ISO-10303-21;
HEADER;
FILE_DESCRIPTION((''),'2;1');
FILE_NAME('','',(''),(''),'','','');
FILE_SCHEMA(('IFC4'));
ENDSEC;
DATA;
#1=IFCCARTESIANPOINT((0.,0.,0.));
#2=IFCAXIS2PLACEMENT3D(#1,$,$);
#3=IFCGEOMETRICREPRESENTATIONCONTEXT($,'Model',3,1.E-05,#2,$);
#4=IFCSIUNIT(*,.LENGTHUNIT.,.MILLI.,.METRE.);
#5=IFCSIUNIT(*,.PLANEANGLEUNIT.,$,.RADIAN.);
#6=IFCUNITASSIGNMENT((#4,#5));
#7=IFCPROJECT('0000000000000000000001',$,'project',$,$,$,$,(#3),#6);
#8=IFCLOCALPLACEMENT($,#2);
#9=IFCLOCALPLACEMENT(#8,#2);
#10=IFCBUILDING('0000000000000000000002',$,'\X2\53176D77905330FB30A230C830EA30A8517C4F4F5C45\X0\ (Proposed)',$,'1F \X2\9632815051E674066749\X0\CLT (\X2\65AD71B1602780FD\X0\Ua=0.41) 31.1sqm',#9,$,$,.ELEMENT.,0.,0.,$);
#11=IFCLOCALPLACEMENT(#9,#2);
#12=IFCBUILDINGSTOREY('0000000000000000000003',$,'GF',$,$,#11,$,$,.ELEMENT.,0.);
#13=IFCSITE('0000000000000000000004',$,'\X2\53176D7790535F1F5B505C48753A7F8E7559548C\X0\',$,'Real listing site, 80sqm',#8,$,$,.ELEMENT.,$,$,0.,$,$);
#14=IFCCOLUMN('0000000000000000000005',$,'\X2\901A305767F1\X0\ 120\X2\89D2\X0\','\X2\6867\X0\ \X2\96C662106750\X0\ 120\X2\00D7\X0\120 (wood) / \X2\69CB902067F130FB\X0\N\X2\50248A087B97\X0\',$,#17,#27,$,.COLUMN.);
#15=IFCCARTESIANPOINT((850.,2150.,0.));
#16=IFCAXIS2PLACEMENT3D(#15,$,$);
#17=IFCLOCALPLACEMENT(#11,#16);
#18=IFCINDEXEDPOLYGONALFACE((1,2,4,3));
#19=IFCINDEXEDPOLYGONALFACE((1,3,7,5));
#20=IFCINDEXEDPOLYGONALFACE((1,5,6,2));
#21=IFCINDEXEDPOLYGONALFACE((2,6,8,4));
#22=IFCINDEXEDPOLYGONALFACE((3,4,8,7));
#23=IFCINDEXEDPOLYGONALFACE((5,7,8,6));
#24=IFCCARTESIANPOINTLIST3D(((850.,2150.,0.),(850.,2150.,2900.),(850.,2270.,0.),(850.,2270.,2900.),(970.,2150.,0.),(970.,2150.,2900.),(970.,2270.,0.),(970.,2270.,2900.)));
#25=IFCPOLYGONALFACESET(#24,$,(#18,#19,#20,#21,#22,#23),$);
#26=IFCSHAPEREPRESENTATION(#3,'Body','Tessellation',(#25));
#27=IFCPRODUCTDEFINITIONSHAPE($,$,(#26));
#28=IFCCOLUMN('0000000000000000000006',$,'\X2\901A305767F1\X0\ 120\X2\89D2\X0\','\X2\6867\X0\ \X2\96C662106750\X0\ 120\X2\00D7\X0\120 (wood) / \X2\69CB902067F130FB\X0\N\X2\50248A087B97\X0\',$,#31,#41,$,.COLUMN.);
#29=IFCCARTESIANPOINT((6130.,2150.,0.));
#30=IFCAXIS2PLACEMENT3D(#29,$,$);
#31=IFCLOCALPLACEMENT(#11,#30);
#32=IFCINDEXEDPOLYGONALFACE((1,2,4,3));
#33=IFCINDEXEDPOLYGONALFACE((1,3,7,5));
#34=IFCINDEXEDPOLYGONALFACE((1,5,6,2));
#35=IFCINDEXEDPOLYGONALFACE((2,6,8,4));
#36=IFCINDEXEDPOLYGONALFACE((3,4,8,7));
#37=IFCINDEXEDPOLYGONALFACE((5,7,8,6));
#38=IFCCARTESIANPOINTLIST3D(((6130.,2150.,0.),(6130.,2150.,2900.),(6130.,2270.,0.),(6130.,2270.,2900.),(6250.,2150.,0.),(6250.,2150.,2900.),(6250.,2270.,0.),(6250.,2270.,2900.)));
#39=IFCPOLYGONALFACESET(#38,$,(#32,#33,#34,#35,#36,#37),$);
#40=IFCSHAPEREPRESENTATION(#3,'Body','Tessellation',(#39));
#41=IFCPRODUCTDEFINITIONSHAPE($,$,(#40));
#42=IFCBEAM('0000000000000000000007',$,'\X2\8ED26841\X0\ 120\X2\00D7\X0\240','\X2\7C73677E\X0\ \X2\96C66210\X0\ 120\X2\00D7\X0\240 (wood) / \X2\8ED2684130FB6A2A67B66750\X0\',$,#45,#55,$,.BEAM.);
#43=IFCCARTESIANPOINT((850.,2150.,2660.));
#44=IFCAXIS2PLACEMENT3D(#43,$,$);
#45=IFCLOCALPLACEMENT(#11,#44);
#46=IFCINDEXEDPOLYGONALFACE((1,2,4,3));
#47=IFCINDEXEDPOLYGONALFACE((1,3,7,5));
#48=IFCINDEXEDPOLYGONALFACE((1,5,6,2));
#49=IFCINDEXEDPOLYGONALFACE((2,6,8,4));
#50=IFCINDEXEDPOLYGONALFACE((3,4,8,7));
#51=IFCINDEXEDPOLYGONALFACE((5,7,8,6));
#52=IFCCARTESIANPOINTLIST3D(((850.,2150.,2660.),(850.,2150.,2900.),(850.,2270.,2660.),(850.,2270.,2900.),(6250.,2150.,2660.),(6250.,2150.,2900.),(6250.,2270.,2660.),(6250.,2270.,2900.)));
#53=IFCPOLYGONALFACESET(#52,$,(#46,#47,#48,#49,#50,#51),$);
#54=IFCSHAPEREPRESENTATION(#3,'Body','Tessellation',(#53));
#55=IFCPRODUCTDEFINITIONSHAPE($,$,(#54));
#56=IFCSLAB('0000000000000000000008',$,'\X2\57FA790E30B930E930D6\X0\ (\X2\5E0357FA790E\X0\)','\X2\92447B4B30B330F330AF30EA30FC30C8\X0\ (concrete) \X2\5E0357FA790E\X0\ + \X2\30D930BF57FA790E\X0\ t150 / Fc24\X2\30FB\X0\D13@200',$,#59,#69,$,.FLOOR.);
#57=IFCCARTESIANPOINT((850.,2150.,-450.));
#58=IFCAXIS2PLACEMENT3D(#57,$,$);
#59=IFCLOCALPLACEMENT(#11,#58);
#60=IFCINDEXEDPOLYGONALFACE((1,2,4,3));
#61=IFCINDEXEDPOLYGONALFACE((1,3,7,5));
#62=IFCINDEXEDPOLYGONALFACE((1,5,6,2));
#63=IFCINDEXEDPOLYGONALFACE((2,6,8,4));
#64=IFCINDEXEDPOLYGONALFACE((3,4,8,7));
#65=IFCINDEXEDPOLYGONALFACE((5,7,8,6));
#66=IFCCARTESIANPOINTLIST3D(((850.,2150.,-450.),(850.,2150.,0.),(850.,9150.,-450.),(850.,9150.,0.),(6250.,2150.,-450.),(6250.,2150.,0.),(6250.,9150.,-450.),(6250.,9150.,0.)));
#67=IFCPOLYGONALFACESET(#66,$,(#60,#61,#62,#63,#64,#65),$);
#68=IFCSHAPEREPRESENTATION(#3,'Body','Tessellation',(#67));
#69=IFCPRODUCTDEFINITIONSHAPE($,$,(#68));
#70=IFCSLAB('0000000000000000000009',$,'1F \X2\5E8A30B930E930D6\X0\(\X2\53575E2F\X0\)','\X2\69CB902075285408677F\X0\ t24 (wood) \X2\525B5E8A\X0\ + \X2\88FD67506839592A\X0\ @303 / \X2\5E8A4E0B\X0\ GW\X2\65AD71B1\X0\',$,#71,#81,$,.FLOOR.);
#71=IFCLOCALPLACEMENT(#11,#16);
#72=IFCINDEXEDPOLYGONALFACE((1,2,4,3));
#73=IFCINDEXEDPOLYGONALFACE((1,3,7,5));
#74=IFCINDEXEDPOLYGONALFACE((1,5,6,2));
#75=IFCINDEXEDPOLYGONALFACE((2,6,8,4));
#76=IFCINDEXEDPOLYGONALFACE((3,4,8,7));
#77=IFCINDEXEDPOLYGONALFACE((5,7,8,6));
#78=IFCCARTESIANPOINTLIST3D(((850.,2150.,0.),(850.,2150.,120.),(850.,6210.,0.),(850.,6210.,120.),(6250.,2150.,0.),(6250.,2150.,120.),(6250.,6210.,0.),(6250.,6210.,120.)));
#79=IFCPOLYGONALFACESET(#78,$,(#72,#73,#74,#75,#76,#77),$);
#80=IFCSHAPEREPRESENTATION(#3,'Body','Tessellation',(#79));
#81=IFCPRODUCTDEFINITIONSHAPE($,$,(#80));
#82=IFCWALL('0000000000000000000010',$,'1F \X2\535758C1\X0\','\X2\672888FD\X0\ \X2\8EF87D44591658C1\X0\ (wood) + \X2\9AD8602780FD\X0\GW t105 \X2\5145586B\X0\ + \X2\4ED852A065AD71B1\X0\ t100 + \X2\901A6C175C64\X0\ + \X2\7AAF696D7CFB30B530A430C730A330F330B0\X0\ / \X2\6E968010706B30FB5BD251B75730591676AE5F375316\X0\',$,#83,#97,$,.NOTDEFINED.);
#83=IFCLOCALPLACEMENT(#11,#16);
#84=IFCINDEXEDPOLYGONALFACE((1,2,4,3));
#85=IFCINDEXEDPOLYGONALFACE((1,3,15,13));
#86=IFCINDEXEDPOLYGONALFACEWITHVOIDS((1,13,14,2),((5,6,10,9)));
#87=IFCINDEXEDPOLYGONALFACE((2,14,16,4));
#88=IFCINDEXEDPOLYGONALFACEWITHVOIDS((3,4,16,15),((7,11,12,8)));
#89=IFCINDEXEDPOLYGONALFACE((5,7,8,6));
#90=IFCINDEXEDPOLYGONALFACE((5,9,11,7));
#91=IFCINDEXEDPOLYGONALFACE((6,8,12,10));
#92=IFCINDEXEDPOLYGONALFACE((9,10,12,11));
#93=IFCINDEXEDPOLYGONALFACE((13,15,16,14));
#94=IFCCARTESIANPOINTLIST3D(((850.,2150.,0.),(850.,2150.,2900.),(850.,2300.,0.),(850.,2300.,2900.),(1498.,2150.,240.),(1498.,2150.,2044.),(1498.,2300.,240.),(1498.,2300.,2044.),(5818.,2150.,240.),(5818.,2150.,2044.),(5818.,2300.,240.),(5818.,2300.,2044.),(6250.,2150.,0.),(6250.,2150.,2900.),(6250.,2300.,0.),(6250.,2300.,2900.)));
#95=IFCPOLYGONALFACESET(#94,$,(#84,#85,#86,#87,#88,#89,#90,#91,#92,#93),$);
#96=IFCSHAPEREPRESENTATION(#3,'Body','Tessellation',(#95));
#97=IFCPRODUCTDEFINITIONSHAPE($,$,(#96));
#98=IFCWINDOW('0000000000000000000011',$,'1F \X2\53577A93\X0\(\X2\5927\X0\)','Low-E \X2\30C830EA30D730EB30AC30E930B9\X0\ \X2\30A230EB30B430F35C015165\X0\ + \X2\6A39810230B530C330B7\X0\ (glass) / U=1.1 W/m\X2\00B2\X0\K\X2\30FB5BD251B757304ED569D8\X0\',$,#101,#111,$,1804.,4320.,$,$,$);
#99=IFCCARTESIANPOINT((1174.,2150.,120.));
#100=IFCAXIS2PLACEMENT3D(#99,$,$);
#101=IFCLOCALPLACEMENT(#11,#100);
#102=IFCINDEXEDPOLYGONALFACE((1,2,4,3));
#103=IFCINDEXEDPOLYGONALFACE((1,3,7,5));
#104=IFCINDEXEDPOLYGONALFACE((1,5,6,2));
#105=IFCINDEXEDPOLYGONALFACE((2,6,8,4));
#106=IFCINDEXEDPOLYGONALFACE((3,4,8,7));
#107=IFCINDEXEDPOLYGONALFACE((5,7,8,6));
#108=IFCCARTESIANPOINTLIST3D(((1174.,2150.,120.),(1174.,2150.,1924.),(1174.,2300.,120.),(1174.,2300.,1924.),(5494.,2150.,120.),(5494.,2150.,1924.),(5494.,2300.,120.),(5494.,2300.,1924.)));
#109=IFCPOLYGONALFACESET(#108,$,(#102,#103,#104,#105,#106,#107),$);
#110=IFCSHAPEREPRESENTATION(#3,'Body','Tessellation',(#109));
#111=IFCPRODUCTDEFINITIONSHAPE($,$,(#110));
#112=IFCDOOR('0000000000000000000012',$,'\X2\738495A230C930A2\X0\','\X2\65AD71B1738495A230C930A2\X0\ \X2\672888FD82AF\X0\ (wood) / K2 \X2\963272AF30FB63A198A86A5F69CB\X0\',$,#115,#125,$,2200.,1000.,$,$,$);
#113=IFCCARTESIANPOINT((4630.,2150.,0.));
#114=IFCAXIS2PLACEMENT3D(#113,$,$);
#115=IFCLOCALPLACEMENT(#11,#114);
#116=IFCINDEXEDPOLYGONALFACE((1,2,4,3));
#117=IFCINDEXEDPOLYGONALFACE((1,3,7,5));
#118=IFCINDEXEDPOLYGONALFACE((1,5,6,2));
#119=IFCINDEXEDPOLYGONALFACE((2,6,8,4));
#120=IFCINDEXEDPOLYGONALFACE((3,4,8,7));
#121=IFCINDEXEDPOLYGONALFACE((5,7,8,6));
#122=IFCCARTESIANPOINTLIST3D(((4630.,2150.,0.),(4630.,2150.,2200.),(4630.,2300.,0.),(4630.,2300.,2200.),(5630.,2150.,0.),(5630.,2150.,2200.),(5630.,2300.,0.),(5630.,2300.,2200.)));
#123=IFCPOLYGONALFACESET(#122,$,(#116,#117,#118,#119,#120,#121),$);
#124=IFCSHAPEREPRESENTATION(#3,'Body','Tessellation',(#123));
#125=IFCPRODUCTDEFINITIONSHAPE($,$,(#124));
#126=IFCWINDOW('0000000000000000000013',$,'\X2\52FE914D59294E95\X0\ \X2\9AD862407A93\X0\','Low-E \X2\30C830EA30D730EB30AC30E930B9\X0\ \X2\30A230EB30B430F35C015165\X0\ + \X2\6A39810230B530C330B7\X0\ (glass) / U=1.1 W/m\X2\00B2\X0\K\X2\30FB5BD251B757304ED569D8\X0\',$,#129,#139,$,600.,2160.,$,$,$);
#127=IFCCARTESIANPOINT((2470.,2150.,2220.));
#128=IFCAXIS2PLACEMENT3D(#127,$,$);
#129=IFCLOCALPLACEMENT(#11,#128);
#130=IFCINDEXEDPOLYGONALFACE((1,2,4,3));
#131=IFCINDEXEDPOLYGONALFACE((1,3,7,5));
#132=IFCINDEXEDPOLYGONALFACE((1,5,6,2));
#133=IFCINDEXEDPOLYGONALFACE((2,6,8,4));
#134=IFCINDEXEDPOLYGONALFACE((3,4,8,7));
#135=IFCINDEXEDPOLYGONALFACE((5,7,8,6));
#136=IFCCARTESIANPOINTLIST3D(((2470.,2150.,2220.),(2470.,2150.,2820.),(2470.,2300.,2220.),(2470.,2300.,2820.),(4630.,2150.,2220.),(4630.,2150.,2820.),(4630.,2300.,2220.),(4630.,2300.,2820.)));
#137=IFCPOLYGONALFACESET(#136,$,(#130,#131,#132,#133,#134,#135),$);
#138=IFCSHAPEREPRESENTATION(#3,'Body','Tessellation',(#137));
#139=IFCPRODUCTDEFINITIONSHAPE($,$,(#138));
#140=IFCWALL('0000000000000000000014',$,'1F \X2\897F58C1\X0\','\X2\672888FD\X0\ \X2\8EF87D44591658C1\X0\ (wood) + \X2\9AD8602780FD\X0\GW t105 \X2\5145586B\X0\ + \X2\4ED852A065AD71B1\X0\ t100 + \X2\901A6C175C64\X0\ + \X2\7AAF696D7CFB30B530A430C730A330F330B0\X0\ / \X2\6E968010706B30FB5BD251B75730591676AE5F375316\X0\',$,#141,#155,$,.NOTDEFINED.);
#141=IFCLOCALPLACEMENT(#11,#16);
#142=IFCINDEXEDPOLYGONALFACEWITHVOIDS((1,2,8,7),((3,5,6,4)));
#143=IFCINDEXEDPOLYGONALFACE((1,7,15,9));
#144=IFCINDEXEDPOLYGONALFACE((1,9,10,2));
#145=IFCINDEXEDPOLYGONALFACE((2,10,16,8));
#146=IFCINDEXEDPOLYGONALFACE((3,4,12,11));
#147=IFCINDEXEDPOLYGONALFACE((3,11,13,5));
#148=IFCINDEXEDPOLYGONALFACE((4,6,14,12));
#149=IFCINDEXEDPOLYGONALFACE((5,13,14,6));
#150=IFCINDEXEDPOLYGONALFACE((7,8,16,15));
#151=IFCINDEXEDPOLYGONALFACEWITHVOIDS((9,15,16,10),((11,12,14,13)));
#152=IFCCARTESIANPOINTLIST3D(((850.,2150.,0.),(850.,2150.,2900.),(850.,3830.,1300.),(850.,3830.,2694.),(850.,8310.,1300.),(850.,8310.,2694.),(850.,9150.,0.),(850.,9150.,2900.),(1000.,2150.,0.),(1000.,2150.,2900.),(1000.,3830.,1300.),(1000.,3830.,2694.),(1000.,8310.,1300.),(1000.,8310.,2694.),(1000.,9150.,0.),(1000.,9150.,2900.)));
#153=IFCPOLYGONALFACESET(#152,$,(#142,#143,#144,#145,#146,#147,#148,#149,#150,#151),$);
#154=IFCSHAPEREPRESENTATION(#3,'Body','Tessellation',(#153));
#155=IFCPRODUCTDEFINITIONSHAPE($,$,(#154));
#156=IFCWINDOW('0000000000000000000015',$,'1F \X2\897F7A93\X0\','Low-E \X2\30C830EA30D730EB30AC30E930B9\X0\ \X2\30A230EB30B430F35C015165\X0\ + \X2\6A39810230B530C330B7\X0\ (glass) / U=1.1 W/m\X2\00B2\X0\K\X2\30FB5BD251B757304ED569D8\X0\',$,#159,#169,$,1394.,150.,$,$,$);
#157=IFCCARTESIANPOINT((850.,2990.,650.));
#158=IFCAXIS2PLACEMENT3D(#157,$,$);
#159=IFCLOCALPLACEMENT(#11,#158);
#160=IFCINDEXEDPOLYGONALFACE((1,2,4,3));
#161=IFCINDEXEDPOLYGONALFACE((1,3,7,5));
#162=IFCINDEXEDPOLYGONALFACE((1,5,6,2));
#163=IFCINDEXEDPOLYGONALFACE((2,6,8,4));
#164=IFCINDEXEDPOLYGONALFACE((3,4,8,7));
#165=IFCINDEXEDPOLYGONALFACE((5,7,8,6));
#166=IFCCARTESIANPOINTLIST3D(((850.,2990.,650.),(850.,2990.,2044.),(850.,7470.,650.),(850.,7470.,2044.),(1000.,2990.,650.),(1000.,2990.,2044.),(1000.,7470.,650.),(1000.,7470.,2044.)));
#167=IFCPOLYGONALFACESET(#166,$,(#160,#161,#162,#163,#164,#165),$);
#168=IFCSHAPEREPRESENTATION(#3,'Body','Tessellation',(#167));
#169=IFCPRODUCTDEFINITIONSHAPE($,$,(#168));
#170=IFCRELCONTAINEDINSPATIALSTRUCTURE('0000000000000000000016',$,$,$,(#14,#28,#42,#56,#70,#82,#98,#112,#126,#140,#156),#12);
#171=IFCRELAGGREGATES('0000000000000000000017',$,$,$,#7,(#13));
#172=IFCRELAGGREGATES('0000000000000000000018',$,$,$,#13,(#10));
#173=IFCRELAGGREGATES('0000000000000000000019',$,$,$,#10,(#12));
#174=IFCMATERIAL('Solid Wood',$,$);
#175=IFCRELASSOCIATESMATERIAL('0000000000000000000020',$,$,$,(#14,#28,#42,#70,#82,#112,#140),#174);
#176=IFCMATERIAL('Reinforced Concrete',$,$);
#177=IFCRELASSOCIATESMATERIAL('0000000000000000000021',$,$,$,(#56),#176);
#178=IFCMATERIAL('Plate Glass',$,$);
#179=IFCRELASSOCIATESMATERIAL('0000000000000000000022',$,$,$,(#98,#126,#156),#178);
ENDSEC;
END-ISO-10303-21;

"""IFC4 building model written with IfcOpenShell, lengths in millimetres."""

from ifc_helpers import new_model, si_unit, frame, frame_2d, origin, place, context, project, spatial, rectangle, extrude, material, element, fill, save


model = new_model("IFC4")

# Units and contexts
model_context = context("Model", 3, precision=1e-05, world=origin())
ifc_project = project(units=[si_unit("LENGTHUNIT", "METRE", prefix="MILLI"), si_unit("PLANEANGLEUNIT", "RADIAN")], contexts=[model_context])

# Site, building, storey
site_placement = place(None, origin())
site = spatial("IfcSite", under=ifc_project, at=site_placement, Name="北海道弟子屈町美留和", ObjectType="Real listing site, 80sqm", CompositionType="ELEMENT", RefElevation=0.0)
building_placement = place(site_placement, origin())
building = spatial("IfcBuilding", under=site, at=building_placement, Name="北海道・アトリエ兼住居 (Proposed)", ObjectType="1F 防腐処理杉CLT (断熱性能Ua=0.41) 31.1sqm", CompositionType="ELEMENT", ElevationOfRefHeight=0.0, ElevationOfTerrain=0.0)
storey_placement = place(building_placement, origin())
storey = spatial("IfcBuildingStorey", under=building, at=storey_placement, Name="GF", CompositionType="ELEMENT", Elevation=0.0)

# Columns
ifc_material_1 = material(Name="Solid Wood")
column_1_placement = place(storey_placement, frame((850.0, 2150.0, 0.0)))
element("IfcColumn", 1, at=column_1_placement, inside=storey, material=ifc_material_1, Name="通し柱 120角", Description="桧 集成材 120×120 (wood) / 構造柱・N値計算", PredefinedType="COLUMN", context=model_context, shape_type="SweptSolid", body=[
    extrude(rectangle(XDim=120.0, YDim=120.0, at=frame_2d((60.0, 60.0))), frame((850.0, 2150.0, 0.0)), (0.0, 0.0, 1.0), 2900.0),
])
column_2_placement = place(storey_placement, frame((6130.0, 2150.0, 0.0)))
element("IfcColumn", 2, at=column_2_placement, inside=storey, material=ifc_material_1, Name="通し柱 120角", Description="桧 集成材 120×120 (wood) / 構造柱・N値計算", PredefinedType="COLUMN", context=model_context, shape_type="SweptSolid", body=[
    extrude(rectangle(XDim=120.0, YDim=120.0, at=frame_2d((60.0, 60.0))), frame((6130.0, 2150.0, 0.0)), (0.0, 0.0, 1.0), 2900.0),
])

# Beam
beam_1_placement = place(storey_placement, frame((850.0, 2150.0, 2660.0)))
element("IfcBeam", 3, at=beam_1_placement, inside=storey, material=ifc_material_1, Name="軒桁 120×240", Description="米松 集成 120×240 (wood) / 軒桁・横架材", PredefinedType="BEAM", context=model_context, shape_type="SweptSolid", body=[
    extrude(rectangle(XDim=5400.0, YDim=120.0, at=frame_2d((2700.0, 60.0))), frame((850.0, 2150.0, 2660.0)), (0.0, 0.0, 1.0), 240.0),
])

# Slabs
ifc_material_2 = material(Name="Reinforced Concrete")
slab_1_placement = place(storey_placement, frame((850.0, 2150.0, -450.0)))
element("IfcSlab", 4, at=slab_1_placement, inside=storey, material=ifc_material_2, Name="基礎スラブ (布基礎)", Description="鉄筋コンクリート (concrete) 布基礎 + ベタ基礎 t150 / Fc24・D13@200", PredefinedType="FLOOR", context=model_context, shape_type="SweptSolid", body=[
    extrude(rectangle(XDim=5400.0, YDim=7000.0, at=frame_2d((2700.0, 3500.0))), frame((850.0, 2150.0, -450.0)), (0.0, 0.0, 1.0), 450.0),
])
slab_2_placement = place(storey_placement, frame((850.0, 2150.0, 0.0)))
element("IfcSlab", 5, at=slab_2_placement, inside=storey, material=ifc_material_1, Name="1F 床スラブ(南帯)", Description="構造用合板 t24 (wood) 剛床 + 製材根太 @303 / 床下 GW断熱", PredefinedType="FLOOR", context=model_context, shape_type="SweptSolid", body=[
    extrude(rectangle(XDim=5400.0, YDim=4060.0, at=frame_2d((2700.0, 2030.0))), frame((850.0, 2150.0, 0.0)), (0.0, 0.0, 1.0), 120.0),
])

# Wall, openings, windows, door
wall_1_placement = place(storey_placement, frame((850.0, 2150.0, 0.0)))
wall_1 = element("IfcWall", 6, at=wall_1_placement, inside=storey, material=ifc_material_1, Name="1F 南壁", Description="木製 軸組外壁 (wood) + 高性能GW t105 充填 + 付加断熱 t100 + 通気層 + 窯業系サイディング / 準耐火・寒冷地外皮強化", PredefinedType="NOTDEFINED", context=model_context, shape_type="SweptSolid", body=[
    extrude(rectangle(XDim=5400.0, YDim=150.0, at=frame_2d((2700.0, 75.0))), frame((850.0, 2150.0, 0.0)), (0.0, 0.0, 1.0), 2900.0),
])
opening_1_placement = place(storey_placement, frame((1174.0, 2150.0, 120.0)))
opening_1 = element("IfcOpeningElement", 7, at=opening_1_placement, cuts=wall_1, PredefinedType="NOTDEFINED", context=model_context, shape_type="SweptSolid", body=[
    extrude(rectangle(XDim=4320.0, YDim=150.0, at=frame_2d((2160.0, 75.0))), frame((1174.0, 2150.0, 120.0)), (0.0, 0.0, 1.0), 1804.0),
])
opening_2_placement = place(storey_placement, frame((4630.0, 2150.0, 0.0)))
opening_2 = element("IfcOpeningElement", 8, at=opening_2_placement, cuts=wall_1, PredefinedType="NOTDEFINED", context=model_context, shape_type="SweptSolid", body=[
    extrude(rectangle(XDim=1000.0, YDim=150.0, at=frame_2d((500.0, 75.0))), frame((4630.0, 2150.0, 0.0)), (0.0, 0.0, 1.0), 2200.0),
])
opening_3_placement = place(storey_placement, frame((2470.0, 2150.0, 2220.0)))
opening_3 = element("IfcOpeningElement", 9, at=opening_3_placement, cuts=wall_1, PredefinedType="NOTDEFINED", context=model_context, shape_type="SweptSolid", body=[
    extrude(rectangle(XDim=2160.0, YDim=150.0, at=frame_2d((1080.0, 75.0))), frame((2470.0, 2150.0, 2220.0)), (0.0, 0.0, 1.0), 600.0),
])
ifc_material_3 = material(Name="Plate Glass")
window_1_placement = place(storey_placement, frame((1174.0, 2150.0, 120.0)))
window_1 = element("IfcWindow", 10, at=window_1_placement, inside=storey, material=ifc_material_3, Name="1F 南窓(大)", Description="Low-E トリプルガラス アルゴン封入 + 樹脂サッシ (glass) / U=1.1 W/m²K・寒冷地仕様", OverallHeight=1804.0, OverallWidth=4320.0, context=model_context, shape_type="SweptSolid", body=[
    extrude(rectangle(XDim=4320.0, YDim=150.0, at=frame_2d((2160.0, 75.0))), frame((1174.0, 2150.0, 120.0)), (0.0, 0.0, 1.0), 1804.0),
])
fill(opening_1, window_1)
door_1_placement = place(storey_placement, frame((4630.0, 2150.0, 0.0)))
door_1 = element("IfcDoor", 11, at=door_1_placement, inside=storey, material=ifc_material_1, Name="玄関ドア", Description="断熱玄関ドア 木製芯 (wood) / K2 防犯・採風機構", OverallHeight=2200.0, OverallWidth=1000.0, context=model_context, shape_type="SweptSolid", body=[
    extrude(rectangle(XDim=1000.0, YDim=150.0, at=frame_2d((500.0, 75.0))), frame((4630.0, 2150.0, 0.0)), (0.0, 0.0, 1.0), 2200.0),
])
fill(opening_2, door_1)
window_2_placement = place(storey_placement, frame((2470.0, 2150.0, 2220.0)))
window_2 = element("IfcWindow", 12, at=window_2_placement, inside=storey, material=ifc_material_3, Name="勾配天井 高所窓", Description="Low-E トリプルガラス アルゴン封入 + 樹脂サッシ (glass) / U=1.1 W/m²K・寒冷地仕様", OverallHeight=600.0, OverallWidth=2160.0, context=model_context, shape_type="SweptSolid", body=[
    extrude(rectangle(XDim=2160.0, YDim=150.0, at=frame_2d((1080.0, 75.0))), frame((2470.0, 2150.0, 2220.0)), (0.0, 0.0, 1.0), 600.0),
])
fill(opening_3, window_2)

# Wall, opening, window
wall_2_placement = place(storey_placement, frame((850.0, 2150.0, 0.0)))
wall_2 = element("IfcWall", 13, at=wall_2_placement, inside=storey, material=ifc_material_1, Name="1F 西壁", Description="木製 軸組外壁 (wood) + 高性能GW t105 充填 + 付加断熱 t100 + 通気層 + 窯業系サイディング / 準耐火・寒冷地外皮強化", PredefinedType="NOTDEFINED", context=model_context, shape_type="SweptSolid", body=[
    extrude(rectangle(XDim=150.0, YDim=7000.0, at=frame_2d((75.0, 3500.0))), frame((850.0, 2150.0, 0.0)), (0.0, 0.0, 1.0), 2900.0),
])
opening_4_placement = place(storey_placement, frame((850.0, 2990.0, 650.0)))
opening_4 = element("IfcOpeningElement", 14, at=opening_4_placement, cuts=wall_2, PredefinedType="NOTDEFINED", context=model_context, shape_type="SweptSolid", body=[
    extrude(rectangle(XDim=150.0, YDim=4480.0, at=frame_2d((75.0, 2240.0))), frame((850.0, 2990.0, 650.0)), (0.0, 0.0, 1.0), 1394.0),
])
window_3_placement = place(storey_placement, frame((850.0, 2990.0, 650.0)))
window_3 = element("IfcWindow", 15, at=window_3_placement, inside=storey, material=ifc_material_3, Name="1F 西窓", Description="Low-E トリプルガラス アルゴン封入 + 樹脂サッシ (glass) / U=1.1 W/m²K・寒冷地仕様", OverallHeight=1394.0, OverallWidth=150.0, context=model_context, shape_type="SweptSolid", body=[
    extrude(rectangle(XDim=150.0, YDim=4480.0, at=frame_2d((75.0, 2240.0))), frame((850.0, 2990.0, 650.0)), (0.0, 0.0, 1.0), 1394.0),
])
fill(opening_4, window_3)

save(model, "model.ifc")
